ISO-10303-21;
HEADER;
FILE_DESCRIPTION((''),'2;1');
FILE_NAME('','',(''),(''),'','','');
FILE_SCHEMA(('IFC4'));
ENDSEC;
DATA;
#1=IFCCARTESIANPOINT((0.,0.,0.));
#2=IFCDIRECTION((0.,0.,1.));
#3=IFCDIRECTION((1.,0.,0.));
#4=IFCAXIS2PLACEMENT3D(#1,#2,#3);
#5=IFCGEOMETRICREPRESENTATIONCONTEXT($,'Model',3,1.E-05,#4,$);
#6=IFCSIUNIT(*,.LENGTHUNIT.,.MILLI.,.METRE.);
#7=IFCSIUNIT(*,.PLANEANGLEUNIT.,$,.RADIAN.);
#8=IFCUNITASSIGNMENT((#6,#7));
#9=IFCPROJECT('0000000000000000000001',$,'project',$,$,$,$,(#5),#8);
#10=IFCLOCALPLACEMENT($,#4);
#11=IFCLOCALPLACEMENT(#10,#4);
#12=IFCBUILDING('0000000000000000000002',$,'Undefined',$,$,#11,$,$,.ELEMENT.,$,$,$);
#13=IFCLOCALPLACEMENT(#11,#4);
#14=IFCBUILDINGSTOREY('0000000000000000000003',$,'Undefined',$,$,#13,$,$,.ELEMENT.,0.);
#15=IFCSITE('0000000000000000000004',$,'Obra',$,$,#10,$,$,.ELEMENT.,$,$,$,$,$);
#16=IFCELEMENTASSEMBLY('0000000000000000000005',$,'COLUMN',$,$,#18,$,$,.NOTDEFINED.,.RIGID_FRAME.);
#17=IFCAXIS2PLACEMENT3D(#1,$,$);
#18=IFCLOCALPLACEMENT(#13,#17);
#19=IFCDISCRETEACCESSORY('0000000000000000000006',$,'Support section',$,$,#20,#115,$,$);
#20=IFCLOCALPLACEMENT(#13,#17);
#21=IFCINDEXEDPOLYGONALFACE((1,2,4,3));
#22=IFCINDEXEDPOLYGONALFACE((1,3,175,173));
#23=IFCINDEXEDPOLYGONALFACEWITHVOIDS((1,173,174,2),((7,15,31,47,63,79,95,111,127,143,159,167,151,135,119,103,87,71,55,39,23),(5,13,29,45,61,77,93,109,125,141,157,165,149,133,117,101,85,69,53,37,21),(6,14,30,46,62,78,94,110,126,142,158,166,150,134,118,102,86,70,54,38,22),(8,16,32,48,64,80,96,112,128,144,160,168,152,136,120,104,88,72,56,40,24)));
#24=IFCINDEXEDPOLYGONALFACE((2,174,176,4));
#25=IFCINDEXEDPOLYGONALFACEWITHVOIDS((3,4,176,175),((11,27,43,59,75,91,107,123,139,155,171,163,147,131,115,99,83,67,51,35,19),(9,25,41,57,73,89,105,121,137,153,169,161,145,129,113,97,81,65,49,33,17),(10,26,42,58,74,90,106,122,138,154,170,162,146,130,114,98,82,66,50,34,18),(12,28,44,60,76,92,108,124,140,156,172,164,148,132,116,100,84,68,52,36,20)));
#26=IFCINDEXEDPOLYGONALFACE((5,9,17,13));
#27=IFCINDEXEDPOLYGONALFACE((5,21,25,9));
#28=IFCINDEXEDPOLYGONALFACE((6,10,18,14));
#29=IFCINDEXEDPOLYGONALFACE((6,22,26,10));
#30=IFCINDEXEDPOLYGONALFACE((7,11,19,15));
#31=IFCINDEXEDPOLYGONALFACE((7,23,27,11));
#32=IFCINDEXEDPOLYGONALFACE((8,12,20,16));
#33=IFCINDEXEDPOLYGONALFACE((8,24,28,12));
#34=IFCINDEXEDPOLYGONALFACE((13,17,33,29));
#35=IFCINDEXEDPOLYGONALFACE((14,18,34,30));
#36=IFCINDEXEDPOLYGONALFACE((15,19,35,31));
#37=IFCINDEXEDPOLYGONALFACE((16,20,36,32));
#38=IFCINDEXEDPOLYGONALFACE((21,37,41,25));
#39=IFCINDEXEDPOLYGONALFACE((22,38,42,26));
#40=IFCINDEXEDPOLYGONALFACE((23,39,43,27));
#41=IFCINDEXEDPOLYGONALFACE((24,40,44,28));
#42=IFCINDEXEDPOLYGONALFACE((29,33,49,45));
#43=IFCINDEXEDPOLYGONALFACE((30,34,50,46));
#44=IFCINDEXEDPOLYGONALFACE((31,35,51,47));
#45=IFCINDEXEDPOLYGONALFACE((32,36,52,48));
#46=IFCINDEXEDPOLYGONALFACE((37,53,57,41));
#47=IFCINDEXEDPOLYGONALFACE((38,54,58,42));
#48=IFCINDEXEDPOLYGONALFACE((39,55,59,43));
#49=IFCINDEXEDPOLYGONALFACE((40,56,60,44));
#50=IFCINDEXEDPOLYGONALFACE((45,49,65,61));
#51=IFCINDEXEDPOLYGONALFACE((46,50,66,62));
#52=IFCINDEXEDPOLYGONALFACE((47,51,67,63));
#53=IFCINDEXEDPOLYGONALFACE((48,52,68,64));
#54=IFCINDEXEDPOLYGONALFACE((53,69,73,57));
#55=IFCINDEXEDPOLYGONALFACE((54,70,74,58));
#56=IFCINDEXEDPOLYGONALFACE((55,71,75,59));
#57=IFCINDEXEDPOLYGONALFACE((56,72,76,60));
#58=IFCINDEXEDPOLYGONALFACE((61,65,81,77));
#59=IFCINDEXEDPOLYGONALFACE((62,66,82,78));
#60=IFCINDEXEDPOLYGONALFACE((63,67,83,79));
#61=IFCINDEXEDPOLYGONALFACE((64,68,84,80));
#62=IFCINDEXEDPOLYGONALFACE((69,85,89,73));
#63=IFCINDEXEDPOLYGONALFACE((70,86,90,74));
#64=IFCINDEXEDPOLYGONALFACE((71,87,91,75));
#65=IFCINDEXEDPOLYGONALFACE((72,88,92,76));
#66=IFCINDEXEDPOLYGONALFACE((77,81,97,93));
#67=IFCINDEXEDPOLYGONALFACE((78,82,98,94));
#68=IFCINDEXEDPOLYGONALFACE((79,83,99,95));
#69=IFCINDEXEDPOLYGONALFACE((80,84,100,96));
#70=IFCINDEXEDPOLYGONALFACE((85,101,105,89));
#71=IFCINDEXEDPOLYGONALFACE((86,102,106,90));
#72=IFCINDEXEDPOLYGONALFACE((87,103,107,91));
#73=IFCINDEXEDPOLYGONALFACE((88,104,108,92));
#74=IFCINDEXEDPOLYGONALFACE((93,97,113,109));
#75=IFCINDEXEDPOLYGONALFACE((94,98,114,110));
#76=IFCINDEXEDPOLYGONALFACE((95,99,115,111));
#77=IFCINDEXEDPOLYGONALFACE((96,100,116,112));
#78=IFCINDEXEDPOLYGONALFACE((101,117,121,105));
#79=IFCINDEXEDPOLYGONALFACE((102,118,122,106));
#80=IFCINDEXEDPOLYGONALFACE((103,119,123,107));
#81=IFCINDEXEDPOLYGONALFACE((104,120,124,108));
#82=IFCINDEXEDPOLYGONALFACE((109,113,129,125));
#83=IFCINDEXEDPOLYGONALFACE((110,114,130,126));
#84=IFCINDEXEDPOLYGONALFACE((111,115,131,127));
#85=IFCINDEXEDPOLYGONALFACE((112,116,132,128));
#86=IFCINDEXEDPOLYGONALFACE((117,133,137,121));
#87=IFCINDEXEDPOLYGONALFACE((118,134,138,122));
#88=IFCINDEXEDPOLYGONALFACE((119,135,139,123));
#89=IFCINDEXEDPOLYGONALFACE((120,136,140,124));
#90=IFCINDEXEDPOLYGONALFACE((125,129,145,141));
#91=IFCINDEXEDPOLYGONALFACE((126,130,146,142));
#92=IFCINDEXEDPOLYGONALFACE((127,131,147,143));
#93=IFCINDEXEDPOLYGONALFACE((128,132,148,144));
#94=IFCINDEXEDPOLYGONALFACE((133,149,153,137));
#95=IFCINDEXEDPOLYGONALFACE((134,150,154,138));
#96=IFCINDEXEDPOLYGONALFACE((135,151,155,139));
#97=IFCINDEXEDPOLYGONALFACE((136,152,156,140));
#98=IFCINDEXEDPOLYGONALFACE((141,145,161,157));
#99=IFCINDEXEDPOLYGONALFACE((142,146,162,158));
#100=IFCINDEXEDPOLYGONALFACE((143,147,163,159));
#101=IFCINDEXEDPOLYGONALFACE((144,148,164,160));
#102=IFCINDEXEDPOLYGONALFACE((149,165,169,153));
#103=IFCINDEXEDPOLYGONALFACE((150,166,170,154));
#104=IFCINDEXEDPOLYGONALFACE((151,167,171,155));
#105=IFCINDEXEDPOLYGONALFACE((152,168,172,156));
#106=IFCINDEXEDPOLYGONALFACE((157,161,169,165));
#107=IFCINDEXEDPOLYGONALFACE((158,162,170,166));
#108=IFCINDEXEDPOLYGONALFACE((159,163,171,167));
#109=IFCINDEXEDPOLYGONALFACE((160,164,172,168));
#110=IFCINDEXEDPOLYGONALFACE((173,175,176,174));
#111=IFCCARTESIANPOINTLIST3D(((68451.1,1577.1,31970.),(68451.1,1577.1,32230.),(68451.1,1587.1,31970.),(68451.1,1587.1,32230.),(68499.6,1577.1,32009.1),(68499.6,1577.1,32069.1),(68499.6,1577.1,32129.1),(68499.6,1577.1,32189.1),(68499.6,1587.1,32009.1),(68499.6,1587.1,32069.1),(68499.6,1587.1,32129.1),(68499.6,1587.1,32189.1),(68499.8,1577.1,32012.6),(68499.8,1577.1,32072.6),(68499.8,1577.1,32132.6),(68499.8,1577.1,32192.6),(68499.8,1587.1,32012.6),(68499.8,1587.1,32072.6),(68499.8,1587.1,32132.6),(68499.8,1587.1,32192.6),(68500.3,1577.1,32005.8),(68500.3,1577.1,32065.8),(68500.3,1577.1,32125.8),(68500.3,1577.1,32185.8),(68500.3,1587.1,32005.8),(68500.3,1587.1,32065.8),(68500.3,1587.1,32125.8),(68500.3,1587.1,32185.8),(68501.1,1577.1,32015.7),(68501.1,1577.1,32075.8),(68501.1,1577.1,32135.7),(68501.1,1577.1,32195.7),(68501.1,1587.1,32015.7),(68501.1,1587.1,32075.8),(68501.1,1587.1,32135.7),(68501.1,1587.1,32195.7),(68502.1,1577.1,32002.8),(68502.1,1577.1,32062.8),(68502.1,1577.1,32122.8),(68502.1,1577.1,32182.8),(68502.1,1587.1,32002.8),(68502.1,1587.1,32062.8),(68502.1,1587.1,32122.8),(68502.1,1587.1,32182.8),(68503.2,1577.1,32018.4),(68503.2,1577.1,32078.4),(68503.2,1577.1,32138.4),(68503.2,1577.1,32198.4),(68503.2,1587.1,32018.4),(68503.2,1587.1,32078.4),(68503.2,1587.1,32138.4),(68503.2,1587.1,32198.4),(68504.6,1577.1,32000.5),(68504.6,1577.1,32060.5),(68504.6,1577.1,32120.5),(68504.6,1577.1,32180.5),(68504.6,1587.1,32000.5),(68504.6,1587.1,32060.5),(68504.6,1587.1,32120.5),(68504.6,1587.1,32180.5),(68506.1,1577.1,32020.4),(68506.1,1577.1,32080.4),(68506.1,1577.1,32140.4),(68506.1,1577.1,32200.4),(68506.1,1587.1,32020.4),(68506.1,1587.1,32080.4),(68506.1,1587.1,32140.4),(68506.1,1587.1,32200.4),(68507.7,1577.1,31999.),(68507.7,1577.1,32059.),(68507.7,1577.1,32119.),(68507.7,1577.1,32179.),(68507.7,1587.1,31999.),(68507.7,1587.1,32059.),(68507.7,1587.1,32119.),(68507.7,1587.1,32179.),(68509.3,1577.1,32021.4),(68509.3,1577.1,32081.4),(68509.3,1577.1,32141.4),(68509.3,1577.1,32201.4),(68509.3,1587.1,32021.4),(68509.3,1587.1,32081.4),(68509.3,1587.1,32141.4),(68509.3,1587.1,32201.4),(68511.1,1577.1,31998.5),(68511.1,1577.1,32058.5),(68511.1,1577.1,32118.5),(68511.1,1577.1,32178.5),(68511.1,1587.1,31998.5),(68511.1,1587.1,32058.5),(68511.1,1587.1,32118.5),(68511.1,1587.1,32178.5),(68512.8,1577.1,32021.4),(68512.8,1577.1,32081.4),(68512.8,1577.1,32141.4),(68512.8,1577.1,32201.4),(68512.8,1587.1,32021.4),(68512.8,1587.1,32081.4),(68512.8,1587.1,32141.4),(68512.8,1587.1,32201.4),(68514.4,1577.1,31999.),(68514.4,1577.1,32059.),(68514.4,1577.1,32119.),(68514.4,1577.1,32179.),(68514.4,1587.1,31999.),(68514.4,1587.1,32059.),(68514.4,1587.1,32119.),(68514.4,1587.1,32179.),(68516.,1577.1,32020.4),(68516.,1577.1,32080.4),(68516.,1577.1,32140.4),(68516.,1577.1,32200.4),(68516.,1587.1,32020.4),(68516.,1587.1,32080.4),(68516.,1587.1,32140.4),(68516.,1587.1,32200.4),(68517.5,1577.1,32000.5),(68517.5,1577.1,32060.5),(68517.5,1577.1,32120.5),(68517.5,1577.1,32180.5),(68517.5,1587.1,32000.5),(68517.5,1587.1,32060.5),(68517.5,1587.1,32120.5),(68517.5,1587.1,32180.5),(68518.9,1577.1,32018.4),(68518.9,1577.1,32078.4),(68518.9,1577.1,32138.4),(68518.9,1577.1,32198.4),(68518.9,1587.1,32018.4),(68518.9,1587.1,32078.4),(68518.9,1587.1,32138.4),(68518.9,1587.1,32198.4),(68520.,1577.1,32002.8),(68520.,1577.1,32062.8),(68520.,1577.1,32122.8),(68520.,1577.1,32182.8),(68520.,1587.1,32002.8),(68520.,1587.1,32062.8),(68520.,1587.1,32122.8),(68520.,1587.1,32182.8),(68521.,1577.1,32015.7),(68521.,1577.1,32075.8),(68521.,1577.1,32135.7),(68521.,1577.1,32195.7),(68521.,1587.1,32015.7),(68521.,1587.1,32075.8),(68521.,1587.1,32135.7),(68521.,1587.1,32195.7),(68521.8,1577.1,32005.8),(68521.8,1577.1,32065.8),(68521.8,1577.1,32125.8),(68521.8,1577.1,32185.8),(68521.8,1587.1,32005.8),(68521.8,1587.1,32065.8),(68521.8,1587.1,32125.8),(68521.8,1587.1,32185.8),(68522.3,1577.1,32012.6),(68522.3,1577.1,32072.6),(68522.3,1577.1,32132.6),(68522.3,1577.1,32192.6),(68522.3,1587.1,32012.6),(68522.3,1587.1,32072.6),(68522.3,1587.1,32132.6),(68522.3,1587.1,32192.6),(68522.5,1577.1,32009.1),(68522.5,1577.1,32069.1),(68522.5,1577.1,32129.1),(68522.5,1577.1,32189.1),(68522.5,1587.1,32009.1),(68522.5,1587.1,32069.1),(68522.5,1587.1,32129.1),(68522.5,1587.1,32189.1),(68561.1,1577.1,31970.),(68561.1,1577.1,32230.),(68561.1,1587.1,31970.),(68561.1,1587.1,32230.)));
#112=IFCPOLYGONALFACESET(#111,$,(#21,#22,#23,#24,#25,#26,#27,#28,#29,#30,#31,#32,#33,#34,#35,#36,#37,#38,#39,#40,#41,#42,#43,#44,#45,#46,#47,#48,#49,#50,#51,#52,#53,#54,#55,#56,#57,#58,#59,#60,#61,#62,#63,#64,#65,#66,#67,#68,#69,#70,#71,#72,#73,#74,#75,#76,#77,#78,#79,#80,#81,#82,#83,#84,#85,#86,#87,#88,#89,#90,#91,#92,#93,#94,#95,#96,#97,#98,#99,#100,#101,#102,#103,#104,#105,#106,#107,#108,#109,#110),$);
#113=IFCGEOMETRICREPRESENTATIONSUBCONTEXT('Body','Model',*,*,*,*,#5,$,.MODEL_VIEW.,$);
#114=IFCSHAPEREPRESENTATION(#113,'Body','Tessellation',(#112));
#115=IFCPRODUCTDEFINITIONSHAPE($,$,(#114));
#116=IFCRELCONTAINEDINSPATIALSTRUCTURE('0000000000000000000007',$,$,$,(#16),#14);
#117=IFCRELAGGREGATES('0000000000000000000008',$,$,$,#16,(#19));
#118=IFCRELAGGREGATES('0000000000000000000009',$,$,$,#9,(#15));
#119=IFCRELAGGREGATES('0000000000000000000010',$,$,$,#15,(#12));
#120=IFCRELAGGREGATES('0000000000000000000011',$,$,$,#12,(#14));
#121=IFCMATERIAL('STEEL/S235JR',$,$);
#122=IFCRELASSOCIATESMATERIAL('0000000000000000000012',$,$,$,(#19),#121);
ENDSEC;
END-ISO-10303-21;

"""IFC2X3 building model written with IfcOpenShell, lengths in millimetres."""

from ifc_helpers import new_model, si_unit, frame, origin_with_axes, origin_2d_with_axis, place, context, subcontext, project, spatial, rectangle, circle, extrude, source, transform, mapped, material, element, aggregate, save


model = new_model("IFC2X3")

# Units and contexts
model_context = context("Model", 3, precision=1e-05, world=origin_with_axes())
body_context = subcontext(model_context, "Body", "Model", "MODEL_VIEW")
ifc_project = project(units=[si_unit("LENGTHUNIT", "METRE", prefix="MILLI"), si_unit("PLANEANGLEUNIT", "RADIAN")], contexts=[model_context])

# Site, building, storey
site_placement = place(None, origin_with_axes())
site = spatial("IfcSite", under=ifc_project, at=site_placement, Name="Obra", CompositionType="ELEMENT")
building_placement = place(site_placement, origin_with_axes())
building = spatial("IfcBuilding", under=site, at=building_placement, Name="Undefined", CompositionType="ELEMENT")
storey_placement = place(building_placement, origin_with_axes())
storey = spatial("IfcBuildingStorey", under=building, at=storey_placement, Name="Undefined", CompositionType="ELEMENT", Elevation=0.0)

# Element assembly
assembly_1_placement = place(storey_placement, origin_with_axes())
assembly_1 = element("IfcElementAssembly", 1, at=assembly_1_placement, inside=storey, Name="COLUMN", AssemblyPlace="NOTDEFINED", PredefinedType="RIGID_FRAME")
ifc_material_1 = material(Name="STEEL/S235JR")

# Discrete accessory, opening
discrete_accessory_1_placement = place(assembly_1_placement, frame((68506.1, 1582.1, 31970.0), z_axis=(0.0, 0.0, 1.0), x_axis=(-1.0, 0.0, 0.0)))
discrete_accessory_1 = element("IfcDiscreteAccessory", 2, at=discrete_accessory_1_placement, material=ifc_material_1, Name="Support section", context=body_context, shape_type="SweptSolid", body=[
    extrude(rectangle(XDim=10.0, YDim=110.0, at=origin_2d_with_axis()), frame((0.0, 0.0, 260.0), z_axis=(0.0, 0.0, -1.0), x_axis=(0.0, 1.0, 0.0)), (0.0, 0.0, 1.0), 260.0),
])
shared_shape_1 = source(origin_with_axes(), body_context, "Body", "SweptSolid", [
    extrude(circle(Radius=11.5, at=origin_2d_with_axis()), frame((0.0, -14.4, 0.0), z_axis=(0.0, 1.0, 0.0), x_axis=(1.0, 0.0, 0.0)), (0.0, 0.0, 1.0), 10.2),
])
opening_1_placement = place(assembly_1_placement, frame((68461.1, 1591.4, 32300.0), z_axis=(1.0, 0.0, 0.0), x_axis=(0.0, 0.0, -1.0)))
element("IfcOpeningElement", 3, at=opening_1_placement, cuts=discrete_accessory_1, ObjectType="Opening", context=body_context, shape_type="MappedRepresentation", body=[
    mapped(shared_shape_1, transform((110.0, 0.0, 50.0))),
    mapped(shared_shape_1, transform((170.0, 0.0, 50.0))),
    mapped(shared_shape_1, transform((230.0, 0.0, 50.0))),
    mapped(shared_shape_1, transform((290.0, 0.0, 50.0))),
])
aggregate(assembly_1, [discrete_accessory_1])

save(model, "model.ifc")
